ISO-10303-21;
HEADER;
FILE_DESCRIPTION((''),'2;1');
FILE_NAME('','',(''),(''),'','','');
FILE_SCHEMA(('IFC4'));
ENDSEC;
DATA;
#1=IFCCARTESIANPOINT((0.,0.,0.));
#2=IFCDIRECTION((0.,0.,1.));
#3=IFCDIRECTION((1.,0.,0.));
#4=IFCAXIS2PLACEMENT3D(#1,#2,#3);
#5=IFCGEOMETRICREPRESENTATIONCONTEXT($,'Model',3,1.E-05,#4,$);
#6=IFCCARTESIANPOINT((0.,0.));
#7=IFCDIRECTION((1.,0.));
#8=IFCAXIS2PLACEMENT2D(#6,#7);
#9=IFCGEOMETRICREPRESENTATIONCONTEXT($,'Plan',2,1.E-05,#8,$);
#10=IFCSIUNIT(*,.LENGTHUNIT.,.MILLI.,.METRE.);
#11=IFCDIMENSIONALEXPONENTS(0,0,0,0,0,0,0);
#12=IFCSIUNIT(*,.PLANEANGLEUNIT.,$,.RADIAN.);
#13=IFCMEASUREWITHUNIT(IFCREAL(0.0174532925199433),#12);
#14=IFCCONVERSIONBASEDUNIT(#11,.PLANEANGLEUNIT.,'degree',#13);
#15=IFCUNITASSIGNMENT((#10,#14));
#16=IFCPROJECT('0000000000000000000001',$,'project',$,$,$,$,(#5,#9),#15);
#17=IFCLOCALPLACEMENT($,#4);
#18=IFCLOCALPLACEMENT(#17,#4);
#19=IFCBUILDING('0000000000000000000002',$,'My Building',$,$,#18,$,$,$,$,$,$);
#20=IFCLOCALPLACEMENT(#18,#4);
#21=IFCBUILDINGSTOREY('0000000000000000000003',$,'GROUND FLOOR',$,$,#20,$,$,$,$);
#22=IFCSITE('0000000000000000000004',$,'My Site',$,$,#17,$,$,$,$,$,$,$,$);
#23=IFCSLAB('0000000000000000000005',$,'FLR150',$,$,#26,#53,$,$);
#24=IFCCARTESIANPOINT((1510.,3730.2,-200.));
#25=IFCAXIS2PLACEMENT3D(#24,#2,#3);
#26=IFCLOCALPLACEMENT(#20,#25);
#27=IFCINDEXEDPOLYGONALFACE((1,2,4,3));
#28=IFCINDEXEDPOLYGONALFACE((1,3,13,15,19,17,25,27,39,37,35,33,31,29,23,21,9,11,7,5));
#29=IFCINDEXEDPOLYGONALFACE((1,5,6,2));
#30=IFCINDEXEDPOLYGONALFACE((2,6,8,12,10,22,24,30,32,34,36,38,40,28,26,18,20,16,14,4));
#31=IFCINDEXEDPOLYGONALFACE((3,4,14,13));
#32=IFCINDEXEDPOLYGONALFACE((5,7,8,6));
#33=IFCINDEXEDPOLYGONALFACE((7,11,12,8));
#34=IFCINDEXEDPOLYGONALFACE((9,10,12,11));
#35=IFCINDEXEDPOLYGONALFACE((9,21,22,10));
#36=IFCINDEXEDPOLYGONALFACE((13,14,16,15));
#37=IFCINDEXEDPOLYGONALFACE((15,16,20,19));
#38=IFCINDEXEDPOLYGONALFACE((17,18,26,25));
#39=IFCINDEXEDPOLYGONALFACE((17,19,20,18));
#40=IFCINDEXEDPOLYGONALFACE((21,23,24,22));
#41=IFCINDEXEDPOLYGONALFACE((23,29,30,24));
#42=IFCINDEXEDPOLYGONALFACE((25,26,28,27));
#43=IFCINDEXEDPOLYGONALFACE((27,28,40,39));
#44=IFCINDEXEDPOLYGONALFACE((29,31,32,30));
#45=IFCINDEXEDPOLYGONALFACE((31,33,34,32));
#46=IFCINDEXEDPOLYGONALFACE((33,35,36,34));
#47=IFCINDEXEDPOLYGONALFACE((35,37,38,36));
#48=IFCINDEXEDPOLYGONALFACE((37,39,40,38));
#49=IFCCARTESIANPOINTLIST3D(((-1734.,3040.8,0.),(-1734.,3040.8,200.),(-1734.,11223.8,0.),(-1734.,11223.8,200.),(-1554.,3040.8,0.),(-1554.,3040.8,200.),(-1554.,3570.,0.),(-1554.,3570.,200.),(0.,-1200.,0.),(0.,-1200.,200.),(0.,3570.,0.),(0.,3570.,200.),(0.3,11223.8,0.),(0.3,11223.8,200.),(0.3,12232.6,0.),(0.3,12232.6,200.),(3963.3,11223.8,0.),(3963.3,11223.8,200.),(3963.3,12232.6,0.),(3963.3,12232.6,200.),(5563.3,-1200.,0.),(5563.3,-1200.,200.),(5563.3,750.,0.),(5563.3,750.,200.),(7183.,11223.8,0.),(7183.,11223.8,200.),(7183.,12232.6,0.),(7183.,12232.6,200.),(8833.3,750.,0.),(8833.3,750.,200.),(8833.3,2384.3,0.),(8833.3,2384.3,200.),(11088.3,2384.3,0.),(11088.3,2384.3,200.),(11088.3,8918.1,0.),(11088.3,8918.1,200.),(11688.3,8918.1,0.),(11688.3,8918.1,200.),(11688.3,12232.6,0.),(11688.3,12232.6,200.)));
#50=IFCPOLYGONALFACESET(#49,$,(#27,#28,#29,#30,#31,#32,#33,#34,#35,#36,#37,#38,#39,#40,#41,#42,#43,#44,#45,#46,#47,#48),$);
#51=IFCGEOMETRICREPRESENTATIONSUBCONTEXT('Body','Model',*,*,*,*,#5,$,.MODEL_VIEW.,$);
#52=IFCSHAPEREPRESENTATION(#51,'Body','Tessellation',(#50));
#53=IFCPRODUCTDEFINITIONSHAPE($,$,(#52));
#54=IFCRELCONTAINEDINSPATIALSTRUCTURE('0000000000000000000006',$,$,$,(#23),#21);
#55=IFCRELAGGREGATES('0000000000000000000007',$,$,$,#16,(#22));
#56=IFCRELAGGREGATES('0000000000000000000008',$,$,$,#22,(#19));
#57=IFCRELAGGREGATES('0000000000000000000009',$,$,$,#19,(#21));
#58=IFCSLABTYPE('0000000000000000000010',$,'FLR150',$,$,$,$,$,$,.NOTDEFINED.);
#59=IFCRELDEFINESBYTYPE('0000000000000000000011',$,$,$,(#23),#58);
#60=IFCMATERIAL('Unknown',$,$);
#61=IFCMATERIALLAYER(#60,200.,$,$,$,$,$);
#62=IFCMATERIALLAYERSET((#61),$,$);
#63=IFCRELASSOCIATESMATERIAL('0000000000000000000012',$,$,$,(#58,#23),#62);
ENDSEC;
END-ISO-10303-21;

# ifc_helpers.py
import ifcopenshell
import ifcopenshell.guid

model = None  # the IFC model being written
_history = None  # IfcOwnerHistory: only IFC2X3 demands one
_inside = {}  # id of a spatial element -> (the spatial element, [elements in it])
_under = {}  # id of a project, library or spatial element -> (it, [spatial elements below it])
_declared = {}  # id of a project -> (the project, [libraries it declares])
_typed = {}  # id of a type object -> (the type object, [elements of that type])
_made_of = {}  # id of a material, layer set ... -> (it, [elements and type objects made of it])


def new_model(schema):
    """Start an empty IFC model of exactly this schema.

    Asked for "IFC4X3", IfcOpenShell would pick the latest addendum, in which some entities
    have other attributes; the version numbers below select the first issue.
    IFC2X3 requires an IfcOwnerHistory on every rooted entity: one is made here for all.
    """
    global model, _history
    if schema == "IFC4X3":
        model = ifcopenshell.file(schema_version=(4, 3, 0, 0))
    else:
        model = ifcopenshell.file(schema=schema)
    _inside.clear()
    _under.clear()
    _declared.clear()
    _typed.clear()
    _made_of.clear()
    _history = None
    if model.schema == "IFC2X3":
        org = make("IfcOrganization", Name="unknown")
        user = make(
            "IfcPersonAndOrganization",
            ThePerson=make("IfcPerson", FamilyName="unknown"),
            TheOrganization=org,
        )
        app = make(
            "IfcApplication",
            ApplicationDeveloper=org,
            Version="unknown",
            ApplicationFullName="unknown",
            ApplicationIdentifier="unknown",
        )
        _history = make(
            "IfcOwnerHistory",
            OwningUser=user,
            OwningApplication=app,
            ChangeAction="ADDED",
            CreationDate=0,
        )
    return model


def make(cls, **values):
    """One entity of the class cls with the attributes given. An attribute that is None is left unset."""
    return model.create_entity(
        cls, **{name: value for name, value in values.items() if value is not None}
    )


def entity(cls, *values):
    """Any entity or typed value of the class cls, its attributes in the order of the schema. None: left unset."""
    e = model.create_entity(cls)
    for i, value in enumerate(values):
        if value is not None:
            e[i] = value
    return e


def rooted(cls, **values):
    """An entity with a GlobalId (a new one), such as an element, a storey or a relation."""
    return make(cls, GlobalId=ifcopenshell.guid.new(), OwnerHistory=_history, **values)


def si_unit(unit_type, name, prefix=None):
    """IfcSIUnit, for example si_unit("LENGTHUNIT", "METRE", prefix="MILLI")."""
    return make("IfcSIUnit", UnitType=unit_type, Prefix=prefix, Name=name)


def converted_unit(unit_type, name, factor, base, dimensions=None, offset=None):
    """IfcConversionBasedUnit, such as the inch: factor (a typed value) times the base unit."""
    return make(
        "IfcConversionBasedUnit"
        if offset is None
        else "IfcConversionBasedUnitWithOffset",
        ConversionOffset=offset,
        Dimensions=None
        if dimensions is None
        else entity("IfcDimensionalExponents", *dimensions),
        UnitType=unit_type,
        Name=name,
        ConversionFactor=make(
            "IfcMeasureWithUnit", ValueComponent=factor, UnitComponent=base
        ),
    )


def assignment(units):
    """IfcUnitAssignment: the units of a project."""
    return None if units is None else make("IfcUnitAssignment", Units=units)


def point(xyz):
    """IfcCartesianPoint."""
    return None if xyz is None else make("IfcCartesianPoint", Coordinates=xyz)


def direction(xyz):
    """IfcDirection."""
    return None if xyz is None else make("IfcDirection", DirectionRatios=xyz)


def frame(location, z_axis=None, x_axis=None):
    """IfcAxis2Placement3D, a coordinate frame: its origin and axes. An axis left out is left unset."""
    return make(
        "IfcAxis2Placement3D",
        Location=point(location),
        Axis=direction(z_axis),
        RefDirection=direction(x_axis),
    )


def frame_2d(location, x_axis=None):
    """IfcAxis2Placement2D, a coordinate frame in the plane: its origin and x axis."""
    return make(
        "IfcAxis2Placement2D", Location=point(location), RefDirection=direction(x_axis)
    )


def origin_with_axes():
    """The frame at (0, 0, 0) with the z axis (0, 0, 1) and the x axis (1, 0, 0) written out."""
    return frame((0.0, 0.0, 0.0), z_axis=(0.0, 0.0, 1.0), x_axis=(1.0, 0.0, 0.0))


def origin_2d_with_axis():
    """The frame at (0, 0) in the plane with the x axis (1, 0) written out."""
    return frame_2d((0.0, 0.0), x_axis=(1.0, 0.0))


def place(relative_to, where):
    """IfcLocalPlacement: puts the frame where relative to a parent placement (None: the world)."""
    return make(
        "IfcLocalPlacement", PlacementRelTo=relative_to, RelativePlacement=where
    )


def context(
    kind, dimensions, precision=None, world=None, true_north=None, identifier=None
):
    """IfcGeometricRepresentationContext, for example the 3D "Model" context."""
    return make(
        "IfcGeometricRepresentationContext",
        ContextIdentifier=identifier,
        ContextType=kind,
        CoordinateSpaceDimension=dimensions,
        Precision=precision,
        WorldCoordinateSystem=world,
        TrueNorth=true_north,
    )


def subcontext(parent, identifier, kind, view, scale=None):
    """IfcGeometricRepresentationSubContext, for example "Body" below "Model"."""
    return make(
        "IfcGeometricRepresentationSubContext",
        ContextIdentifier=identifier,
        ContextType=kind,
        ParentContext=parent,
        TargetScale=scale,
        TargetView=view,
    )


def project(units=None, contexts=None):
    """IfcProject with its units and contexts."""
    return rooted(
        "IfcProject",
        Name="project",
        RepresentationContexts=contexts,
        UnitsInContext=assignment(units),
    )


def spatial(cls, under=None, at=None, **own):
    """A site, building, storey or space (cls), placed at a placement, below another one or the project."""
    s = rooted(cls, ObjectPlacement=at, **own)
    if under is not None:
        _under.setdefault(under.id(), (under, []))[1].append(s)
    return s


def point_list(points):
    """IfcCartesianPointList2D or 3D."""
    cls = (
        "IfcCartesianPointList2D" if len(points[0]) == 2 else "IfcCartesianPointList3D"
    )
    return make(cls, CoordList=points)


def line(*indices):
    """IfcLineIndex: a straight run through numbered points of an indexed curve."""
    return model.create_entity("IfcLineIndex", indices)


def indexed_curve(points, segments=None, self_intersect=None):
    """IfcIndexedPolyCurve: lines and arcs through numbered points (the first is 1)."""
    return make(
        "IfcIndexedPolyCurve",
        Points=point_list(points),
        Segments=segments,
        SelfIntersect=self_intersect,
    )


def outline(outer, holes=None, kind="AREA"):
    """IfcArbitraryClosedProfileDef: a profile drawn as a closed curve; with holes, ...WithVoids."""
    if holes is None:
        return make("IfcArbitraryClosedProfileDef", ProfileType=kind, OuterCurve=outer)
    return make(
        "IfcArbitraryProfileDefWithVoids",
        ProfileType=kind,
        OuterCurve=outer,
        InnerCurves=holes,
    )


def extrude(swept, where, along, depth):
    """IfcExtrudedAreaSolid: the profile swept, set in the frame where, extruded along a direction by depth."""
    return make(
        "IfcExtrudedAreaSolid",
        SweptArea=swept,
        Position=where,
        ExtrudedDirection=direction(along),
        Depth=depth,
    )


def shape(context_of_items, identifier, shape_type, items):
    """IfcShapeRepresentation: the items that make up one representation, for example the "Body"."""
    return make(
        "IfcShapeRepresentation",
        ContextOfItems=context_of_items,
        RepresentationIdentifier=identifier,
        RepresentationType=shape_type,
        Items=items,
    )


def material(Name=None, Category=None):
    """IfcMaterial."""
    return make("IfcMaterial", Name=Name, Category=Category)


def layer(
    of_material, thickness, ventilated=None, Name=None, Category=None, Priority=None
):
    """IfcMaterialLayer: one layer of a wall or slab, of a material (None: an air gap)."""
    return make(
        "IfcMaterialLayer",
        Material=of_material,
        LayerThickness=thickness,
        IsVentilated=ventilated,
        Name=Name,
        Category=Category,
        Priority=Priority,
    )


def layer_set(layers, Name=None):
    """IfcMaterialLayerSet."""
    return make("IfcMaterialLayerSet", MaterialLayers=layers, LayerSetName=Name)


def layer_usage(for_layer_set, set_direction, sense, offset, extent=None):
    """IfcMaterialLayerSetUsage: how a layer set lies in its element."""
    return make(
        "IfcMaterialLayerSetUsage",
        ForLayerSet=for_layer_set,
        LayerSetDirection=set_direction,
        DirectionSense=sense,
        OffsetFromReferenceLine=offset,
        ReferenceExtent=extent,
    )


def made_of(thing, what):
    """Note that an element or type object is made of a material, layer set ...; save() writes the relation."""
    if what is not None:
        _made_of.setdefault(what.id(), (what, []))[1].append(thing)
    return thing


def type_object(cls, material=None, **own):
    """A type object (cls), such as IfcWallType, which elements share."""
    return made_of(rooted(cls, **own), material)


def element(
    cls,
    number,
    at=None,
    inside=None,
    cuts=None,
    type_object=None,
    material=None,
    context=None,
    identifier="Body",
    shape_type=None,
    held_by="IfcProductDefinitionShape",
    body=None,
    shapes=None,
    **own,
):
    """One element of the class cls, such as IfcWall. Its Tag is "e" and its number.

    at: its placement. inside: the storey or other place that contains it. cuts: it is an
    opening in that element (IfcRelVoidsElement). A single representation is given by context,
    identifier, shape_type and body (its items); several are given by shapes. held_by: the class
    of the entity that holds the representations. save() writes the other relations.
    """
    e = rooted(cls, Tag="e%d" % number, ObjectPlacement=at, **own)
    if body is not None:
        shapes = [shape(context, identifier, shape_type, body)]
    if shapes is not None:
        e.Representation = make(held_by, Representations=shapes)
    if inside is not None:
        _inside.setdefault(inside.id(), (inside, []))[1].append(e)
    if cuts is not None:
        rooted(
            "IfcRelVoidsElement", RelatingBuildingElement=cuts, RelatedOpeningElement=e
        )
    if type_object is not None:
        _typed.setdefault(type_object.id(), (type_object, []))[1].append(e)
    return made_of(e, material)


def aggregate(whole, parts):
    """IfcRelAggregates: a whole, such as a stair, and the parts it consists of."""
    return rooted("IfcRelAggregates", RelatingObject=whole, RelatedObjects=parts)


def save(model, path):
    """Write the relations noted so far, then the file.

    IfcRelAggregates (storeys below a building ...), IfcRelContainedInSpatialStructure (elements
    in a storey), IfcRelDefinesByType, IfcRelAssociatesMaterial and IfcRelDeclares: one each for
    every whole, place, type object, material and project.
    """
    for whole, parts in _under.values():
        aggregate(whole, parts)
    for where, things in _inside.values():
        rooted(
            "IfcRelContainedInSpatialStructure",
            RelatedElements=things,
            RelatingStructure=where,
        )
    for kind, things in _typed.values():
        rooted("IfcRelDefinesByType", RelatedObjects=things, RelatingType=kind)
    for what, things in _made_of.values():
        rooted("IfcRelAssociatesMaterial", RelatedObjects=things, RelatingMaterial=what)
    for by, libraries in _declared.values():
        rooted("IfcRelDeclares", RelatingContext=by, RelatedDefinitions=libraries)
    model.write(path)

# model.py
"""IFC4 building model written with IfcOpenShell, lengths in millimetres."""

from ifc_helpers import new_model, entity, si_unit, converted_unit, frame, origin_with_axes, origin_2d_with_axis, place, context, subcontext, project, spatial, line, indexed_curve, outline, extrude, material, layer, layer_set, layer_usage, type_object, element, save


model = new_model("IFC4")

# Units and contexts
model_context = context("Model", 3, precision=1e-05, world=origin_with_axes())
plan_context = context("Plan", 2, precision=1e-05, world=origin_2d_with_axis())
body_context_1 = subcontext(model_context, "Body", "Model", "MODEL_VIEW")
ifc_project = project(units=[si_unit("LENGTHUNIT", "METRE", prefix="MILLI"), converted_unit("PLANEANGLEUNIT", "degree", entity("IfcReal", 0.0174532925199433), si_unit("PLANEANGLEUNIT", "RADIAN"), dimensions=[0, 0, 0, 0, 0, 0, 0])], contexts=[model_context, plan_context])

# Site, building, storey
site_placement = place(None, origin_with_axes())
site = spatial("IfcSite", under=ifc_project, at=site_placement, Name="My Site")
building_placement = place(site_placement, origin_with_axes())
building = spatial("IfcBuilding", under=site, at=building_placement, Name="My Building")
storey_placement = place(building_placement, origin_with_axes())
storey = spatial("IfcBuildingStorey", under=building, at=storey_placement, Name="GROUND FLOOR")

# Slab
ifc_material_1 = material(Name="Unknown")
ifc_layer_1 = layer(ifc_material_1, 200.0)
ifc_layer_set_1 = layer_set([ifc_layer_1])
ifc_layer_usage_1 = layer_usage(ifc_layer_set_1, "AXIS3", "POSITIVE", 0.0)
slab_type = type_object("IfcSlabType", Name="FLR150", PredefinedType="NOTDEFINED", material=ifc_layer_set_1)
slab_placement = place(storey_placement, frame((1510.0, 3730.2, -200.0), z_axis=(0.0, 0.0, 1.0), x_axis=(1.0, 0.0, 0.0)))
element("IfcSlab", 1, at=slab_placement, inside=storey, type_object=slab_type, material=ifc_layer_usage_1, Name="FLR150", context=body_context_1, shape_type="SweptSolid", body=[
    extrude(outline(indexed_curve([(11688.3, 8918.1), (11688.3, 12232.6), (7183.0, 12232.6), (7183.0, 11223.8), (3963.3, 11223.8), (3963.3, 12232.6), (0.3, 12232.6), (0.3, 11223.8), (-1734.0, 11223.8), (-1734.0, 3040.8), (-1554.0, 3040.8), (-1554.0, 3570.0), (0.0, 3570.0), (0.0, -1200.0), (5563.3, -1200.0), (5563.3, 750.0), (8833.3, 750.0), (8833.3, 2384.3), (11088.3, 2384.3), (11088.3, 8918.1)], segments=[line(8, 7), line(7, 6), line(6, 5), line(5, 4), line(4, 3), line(3, 2), line(2, 1), line(1, 20), line(20, 19), line(19, 18), line(18, 17), line(17, 16), line(16, 15), line(15, 14), line(14, 13), line(13, 12), line(12, 11), line(11, 10), line(10, 9), line(9, 8)], self_intersect=False)), None, (0.0, 0.0, 1.0), 200.0),
])

save(model, "model.ifc")
